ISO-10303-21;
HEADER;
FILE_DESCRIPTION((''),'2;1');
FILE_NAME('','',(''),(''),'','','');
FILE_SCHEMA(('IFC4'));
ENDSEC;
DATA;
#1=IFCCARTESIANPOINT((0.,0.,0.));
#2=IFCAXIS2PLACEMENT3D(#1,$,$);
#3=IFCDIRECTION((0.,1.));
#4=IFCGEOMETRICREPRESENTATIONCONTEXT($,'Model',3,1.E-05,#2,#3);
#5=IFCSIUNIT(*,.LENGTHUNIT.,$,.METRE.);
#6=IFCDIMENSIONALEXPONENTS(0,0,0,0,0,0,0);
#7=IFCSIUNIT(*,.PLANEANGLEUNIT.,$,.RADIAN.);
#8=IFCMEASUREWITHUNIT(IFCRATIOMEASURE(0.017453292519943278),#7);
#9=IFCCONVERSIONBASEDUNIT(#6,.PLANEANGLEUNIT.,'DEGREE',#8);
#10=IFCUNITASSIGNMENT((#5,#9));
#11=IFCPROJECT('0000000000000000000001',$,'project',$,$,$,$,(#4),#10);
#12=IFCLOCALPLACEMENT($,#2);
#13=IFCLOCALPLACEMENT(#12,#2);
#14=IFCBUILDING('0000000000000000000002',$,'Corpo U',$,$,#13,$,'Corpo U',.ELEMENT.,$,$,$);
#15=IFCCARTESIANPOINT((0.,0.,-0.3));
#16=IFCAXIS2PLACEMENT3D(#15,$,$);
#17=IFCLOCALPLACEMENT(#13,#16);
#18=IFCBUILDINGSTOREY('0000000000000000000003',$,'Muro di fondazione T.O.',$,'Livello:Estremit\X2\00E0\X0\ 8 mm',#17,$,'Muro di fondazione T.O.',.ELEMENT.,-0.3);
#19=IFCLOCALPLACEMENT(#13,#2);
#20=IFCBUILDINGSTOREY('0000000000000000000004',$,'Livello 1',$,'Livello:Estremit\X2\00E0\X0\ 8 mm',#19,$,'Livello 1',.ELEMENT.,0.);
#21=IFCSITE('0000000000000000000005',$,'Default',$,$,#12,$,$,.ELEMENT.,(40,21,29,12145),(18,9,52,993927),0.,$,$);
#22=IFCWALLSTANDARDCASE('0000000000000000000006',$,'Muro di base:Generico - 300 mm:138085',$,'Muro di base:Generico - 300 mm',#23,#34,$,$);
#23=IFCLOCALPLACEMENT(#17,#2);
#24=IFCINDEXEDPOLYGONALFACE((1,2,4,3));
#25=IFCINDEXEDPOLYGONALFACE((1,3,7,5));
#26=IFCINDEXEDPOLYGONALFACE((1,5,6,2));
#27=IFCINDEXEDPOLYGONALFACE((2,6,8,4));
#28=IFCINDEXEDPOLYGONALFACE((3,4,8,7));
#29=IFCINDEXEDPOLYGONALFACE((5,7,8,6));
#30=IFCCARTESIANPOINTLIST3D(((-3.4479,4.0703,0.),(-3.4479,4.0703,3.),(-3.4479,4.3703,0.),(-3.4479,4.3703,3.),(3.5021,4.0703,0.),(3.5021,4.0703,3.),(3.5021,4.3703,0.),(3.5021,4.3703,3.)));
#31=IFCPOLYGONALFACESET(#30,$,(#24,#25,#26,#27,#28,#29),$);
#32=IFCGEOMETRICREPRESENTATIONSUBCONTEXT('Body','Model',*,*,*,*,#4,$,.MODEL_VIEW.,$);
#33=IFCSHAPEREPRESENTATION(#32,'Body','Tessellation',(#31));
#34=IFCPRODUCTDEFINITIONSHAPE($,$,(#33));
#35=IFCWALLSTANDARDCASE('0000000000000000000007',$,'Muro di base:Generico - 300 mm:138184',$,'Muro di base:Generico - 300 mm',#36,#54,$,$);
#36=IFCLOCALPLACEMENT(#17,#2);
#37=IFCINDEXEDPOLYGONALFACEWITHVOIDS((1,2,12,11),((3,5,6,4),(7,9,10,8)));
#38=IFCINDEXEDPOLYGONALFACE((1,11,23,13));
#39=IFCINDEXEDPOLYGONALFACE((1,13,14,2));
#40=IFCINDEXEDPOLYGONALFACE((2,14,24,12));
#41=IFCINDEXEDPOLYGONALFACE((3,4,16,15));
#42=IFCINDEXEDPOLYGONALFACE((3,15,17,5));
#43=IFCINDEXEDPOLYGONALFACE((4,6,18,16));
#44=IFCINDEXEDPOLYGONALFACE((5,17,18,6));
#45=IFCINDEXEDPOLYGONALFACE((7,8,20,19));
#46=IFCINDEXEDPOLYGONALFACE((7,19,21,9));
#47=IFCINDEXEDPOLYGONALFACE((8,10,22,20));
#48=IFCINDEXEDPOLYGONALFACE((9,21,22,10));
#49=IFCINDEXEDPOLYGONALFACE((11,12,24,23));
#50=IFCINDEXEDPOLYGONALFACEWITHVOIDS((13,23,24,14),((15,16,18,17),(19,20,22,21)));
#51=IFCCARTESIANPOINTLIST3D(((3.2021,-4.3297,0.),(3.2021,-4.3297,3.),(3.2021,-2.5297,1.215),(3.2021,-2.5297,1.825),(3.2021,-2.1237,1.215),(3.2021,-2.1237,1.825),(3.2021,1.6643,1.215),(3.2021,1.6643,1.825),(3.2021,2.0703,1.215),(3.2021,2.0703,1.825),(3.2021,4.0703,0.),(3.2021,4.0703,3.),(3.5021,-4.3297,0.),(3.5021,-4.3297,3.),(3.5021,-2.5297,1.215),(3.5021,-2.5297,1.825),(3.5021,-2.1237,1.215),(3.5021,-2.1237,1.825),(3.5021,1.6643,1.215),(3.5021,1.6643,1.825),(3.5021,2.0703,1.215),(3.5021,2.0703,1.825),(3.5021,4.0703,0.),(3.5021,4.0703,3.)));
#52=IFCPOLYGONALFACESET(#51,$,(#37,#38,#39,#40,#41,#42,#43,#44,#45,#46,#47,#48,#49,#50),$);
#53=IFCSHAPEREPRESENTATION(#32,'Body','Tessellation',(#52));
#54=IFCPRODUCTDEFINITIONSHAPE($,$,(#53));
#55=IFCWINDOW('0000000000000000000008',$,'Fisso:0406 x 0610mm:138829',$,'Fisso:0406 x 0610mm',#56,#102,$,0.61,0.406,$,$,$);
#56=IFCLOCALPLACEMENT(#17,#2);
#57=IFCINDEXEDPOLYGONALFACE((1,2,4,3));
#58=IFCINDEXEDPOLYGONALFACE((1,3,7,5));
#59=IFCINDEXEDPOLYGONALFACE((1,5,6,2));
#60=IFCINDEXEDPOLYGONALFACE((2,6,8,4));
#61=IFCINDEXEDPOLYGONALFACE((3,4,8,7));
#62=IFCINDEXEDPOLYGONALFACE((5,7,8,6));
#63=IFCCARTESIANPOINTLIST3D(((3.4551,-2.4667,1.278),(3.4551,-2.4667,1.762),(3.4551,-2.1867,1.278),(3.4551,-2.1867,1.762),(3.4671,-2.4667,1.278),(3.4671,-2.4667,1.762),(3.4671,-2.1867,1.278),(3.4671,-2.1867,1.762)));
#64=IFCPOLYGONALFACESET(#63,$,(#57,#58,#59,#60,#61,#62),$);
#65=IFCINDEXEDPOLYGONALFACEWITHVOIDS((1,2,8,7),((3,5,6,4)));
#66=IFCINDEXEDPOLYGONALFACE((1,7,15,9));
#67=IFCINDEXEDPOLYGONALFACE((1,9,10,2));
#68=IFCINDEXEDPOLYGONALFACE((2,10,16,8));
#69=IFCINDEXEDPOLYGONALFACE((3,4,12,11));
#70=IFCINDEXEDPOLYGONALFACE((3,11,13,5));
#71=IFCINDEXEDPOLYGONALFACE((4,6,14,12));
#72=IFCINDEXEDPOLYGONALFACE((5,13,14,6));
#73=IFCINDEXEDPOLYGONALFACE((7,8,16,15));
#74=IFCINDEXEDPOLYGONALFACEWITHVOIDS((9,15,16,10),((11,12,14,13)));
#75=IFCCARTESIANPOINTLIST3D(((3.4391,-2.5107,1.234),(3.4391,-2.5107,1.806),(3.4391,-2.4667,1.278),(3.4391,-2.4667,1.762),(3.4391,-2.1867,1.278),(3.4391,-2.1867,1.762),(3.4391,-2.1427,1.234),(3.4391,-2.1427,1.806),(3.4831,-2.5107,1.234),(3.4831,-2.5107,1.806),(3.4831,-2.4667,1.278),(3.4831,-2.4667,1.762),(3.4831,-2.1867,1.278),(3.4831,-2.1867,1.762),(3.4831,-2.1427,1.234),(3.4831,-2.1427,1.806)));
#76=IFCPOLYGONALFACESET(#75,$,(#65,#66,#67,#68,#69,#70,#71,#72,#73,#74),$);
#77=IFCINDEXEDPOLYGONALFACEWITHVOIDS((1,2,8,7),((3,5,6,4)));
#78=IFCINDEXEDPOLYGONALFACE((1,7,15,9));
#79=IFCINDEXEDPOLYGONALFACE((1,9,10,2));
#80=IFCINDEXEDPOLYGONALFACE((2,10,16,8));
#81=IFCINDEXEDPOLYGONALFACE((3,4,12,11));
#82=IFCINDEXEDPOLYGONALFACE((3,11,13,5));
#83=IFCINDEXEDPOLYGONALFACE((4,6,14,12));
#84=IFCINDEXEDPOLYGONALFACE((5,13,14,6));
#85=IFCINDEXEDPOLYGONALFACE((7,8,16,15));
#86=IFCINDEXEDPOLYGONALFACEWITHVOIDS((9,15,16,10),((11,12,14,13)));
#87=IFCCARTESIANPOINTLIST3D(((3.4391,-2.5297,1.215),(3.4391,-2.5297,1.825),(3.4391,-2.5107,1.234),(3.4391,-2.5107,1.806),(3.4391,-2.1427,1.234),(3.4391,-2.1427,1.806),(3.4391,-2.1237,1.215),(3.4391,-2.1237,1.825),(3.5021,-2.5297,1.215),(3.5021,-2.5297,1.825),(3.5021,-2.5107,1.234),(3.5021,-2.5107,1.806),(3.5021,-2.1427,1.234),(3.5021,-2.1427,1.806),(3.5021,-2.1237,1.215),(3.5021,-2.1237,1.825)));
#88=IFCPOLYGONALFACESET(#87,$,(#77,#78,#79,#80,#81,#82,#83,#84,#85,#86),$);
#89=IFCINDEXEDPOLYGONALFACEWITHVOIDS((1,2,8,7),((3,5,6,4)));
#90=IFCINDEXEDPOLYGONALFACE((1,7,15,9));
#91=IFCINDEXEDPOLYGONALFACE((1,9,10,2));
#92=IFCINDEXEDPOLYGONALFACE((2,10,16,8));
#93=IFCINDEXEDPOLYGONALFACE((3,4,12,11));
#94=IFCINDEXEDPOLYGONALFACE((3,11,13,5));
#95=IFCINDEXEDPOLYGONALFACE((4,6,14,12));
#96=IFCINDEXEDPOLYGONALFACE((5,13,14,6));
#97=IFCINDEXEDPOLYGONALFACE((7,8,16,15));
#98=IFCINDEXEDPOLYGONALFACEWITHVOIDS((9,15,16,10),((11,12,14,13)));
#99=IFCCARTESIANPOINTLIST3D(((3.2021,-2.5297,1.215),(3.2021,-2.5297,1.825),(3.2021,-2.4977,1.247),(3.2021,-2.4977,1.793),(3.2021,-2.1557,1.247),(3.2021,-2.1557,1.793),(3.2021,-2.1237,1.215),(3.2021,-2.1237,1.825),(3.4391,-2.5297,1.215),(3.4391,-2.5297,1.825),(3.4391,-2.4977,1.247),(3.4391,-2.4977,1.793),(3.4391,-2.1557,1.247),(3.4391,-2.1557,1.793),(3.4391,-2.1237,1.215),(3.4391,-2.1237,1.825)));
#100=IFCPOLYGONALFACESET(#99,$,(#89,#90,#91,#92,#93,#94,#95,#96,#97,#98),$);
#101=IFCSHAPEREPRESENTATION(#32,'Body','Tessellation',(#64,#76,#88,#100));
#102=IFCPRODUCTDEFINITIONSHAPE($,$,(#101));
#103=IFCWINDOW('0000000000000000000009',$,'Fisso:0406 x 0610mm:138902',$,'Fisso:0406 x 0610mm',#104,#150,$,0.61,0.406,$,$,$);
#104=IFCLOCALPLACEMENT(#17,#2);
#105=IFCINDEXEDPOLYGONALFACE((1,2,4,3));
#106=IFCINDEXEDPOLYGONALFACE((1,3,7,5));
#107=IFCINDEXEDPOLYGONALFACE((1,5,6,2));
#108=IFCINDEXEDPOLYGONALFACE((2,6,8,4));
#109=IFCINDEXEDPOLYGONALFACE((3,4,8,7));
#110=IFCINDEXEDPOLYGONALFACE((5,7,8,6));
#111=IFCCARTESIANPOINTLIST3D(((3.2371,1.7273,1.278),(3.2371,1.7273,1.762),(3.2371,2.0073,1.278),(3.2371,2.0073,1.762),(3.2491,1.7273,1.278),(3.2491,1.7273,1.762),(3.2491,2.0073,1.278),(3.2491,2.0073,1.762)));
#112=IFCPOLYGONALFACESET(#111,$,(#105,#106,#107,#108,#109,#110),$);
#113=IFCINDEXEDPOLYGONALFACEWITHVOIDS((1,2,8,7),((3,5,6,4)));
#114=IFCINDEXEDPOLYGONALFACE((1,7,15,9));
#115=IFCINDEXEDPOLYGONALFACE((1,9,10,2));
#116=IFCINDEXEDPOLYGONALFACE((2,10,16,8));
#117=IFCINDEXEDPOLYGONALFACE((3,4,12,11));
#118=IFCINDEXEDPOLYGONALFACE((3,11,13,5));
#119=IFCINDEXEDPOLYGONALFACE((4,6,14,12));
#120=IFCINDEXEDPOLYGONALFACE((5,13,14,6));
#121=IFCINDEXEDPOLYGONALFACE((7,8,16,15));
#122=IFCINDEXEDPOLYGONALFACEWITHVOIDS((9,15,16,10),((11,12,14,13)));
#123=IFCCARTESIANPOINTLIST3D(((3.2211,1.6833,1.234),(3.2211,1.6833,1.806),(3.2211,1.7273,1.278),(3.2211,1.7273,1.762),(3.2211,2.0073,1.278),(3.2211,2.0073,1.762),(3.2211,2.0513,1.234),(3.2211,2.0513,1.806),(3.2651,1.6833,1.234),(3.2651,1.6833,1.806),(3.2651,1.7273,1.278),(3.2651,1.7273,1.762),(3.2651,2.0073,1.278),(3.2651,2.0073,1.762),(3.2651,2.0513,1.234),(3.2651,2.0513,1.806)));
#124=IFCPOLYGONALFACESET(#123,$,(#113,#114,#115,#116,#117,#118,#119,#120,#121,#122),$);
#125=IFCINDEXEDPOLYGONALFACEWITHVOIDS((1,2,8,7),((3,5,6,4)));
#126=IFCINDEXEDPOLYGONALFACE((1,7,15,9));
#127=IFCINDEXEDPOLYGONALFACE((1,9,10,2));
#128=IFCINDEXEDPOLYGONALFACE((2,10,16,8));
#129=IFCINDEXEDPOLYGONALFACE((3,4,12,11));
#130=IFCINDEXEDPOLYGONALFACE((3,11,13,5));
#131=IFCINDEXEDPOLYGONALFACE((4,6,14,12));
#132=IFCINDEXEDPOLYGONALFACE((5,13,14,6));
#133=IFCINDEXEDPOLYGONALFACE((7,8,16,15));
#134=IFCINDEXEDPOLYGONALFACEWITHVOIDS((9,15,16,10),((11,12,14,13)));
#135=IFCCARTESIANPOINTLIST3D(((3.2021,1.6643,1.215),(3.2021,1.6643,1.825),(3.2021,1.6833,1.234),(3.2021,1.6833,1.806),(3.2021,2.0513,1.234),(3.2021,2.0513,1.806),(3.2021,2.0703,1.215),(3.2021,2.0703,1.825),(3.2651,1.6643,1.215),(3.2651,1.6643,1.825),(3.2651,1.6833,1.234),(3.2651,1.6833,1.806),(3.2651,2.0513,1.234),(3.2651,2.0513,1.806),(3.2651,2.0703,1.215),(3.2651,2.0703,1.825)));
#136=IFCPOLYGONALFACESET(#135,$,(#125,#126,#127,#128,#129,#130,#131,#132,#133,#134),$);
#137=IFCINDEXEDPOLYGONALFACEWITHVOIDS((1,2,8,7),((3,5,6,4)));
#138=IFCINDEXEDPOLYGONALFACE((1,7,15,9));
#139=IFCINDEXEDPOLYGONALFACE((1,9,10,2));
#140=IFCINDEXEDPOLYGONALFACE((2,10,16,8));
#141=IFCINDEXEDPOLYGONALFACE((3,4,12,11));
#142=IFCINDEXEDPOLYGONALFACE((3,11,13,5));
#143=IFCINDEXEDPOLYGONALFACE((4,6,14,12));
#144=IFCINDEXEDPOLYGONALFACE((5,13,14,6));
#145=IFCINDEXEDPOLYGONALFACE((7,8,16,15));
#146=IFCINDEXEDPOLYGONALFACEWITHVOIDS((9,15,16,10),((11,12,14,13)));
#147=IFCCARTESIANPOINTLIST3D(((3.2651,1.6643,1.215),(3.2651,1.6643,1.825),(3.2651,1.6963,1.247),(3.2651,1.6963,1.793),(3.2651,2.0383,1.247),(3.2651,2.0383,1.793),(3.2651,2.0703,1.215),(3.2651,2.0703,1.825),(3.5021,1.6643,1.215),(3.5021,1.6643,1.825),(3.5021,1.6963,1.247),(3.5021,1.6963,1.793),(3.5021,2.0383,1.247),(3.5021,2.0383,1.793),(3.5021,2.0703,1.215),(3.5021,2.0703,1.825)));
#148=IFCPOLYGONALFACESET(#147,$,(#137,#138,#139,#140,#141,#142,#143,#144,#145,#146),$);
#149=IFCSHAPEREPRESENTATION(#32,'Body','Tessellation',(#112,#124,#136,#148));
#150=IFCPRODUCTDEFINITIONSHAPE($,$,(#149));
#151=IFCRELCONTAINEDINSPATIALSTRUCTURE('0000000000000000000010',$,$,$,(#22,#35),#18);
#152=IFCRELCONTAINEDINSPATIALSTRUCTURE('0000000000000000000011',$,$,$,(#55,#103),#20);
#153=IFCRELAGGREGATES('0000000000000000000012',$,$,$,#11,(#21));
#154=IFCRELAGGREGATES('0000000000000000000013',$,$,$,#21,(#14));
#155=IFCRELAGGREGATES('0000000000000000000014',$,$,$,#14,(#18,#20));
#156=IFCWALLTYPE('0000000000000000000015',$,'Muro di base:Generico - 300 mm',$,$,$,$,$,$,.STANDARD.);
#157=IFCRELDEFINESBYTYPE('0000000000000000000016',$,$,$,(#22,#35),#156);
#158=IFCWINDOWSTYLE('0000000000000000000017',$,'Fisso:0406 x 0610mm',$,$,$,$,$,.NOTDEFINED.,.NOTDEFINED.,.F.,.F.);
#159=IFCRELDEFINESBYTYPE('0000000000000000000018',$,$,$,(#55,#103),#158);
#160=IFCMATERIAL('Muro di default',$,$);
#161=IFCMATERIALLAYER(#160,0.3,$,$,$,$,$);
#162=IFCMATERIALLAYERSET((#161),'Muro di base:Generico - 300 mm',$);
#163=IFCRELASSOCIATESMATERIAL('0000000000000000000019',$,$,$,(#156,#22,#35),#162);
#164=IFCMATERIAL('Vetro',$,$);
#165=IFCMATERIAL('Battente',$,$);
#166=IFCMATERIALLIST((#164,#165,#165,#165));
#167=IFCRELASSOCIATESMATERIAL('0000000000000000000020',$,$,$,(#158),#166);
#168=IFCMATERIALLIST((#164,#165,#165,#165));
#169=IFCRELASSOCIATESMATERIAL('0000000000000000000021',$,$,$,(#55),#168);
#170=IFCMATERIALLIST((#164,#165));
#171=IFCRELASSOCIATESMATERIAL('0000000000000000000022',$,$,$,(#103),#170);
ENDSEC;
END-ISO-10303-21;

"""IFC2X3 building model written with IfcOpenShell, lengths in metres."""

from ifc_helpers import new_model, entity, si_unit, converted_unit, direction, frame, frame_2d, origin, place, context, subcontext, project, spatial, polyline, rectangle, outline, extrude, source, transform, mapped, material, material_list, layer, layer_set, layer_usage, type_object, type_shapes, element, fill, save


model = new_model("IFC2X3")

# Units and contexts
model_context = context("Model", 3, precision=1e-05, world=origin(), true_north=direction((0.0, 1.0)))
body_context = subcontext(model_context, "Body", "Model", "MODEL_VIEW")
ifc_project = project(units=[si_unit("LENGTHUNIT", "METRE"), converted_unit("PLANEANGLEUNIT", "DEGREE", entity("IfcRatioMeasure", 0.017453292519943278), si_unit("PLANEANGLEUNIT", "RADIAN"), dimensions=[0, 0, 0, 0, 0, 0, 0])], contexts=[model_context])

# Site, building, storey
site_placement = place(None, origin())
site = spatial("IfcSite", under=ifc_project, at=site_placement, Name="Default", CompositionType="ELEMENT", RefLatitude=(40, 21, 29, 12145), RefLongitude=(18, 9, 52, 993927), RefElevation=0.0)
building_placement = place(site_placement, origin())
building = spatial("IfcBuilding", under=site, at=building_placement, Name="Corpo U", LongName="Corpo U", CompositionType="ELEMENT")
storey_1_placement = place(building_placement, frame((0.0, 0.0, -0.3)))
storey_1 = spatial("IfcBuildingStorey", under=building, at=storey_1_placement, Name="Muro di fondazione T.O.", ObjectType="Livello:Estremità 8 mm", LongName="Muro di fondazione T.O.", CompositionType="ELEMENT", Elevation=-0.3)

# Wall
ifc_material_1 = material(Name="Muro di default")
ifc_layer = layer(ifc_material_1, 0.3)
ifc_layer_set = layer_set([ifc_layer], Name="Muro di base:Generico - 300 mm")
ifc_layer_usage_1 = layer_usage(ifc_layer_set, "AXIS2", "NEGATIVE", 0.15)
wall_type = type_object("IfcWallType", Name="Muro di base:Generico - 300 mm", PredefinedType="STANDARD", material=ifc_layer_set)
wall_1_placement = place(storey_1_placement, frame((-3.4479, 4.2203, 0.0)))
element("IfcWallStandardCase", 1, at=wall_1_placement, inside=storey_1, type_object=wall_type, material=ifc_layer_usage_1, Name="Muro di base:Generico - 300 mm:138085", ObjectType="Muro di base:Generico - 300 mm", context=body_context, shape_type="SweptSolid", body=[
    extrude(rectangle(XDim=6.95, YDim=0.3, at=frame_2d((3.475, 0.0), x_axis=(-1.0, 0.0))), origin(), (0.0, 0.0, 1.0), 3.0),
])

# Wall, openings
ifc_layer_usage_2 = layer_usage(ifc_layer_set, "AXIS2", "NEGATIVE", 0.15)
wall_2_placement = place(storey_1_placement, frame((3.3521, 4.0703, 0.0), z_axis=(0.0, 0.0, 1.0), x_axis=(0.0, -1.0, 0.0)))
wall_2 = element("IfcWallStandardCase", 2, at=wall_2_placement, inside=storey_1, type_object=wall_type, material=ifc_layer_usage_2, Name="Muro di base:Generico - 300 mm:138184", ObjectType="Muro di base:Generico - 300 mm", context=body_context, shape_type="SweptSolid", body=[
    extrude(rectangle(XDim=8.4, YDim=0.3, at=frame_2d((4.2, 0.0), x_axis=(-1.0, 0.0))), origin(), (0.0, 0.0, 1.0), 3.0),
])
opening_1_placement = place(wall_2_placement, frame((6.194, -0.15, 1.215)))
opening_1 = element("IfcOpeningElement", 3, at=opening_1_placement, cuts=wall_2, ObjectType="Opening", context=body_context, shape_type="SweptSolid", body=[
    extrude(rectangle(XDim=0.61, YDim=0.406, at=frame_2d((0.305, 0.203), x_axis=(1.0, 0.0))), frame((0.0, 0.0, 0.0), z_axis=(0.0, 1.0, 0.0), x_axis=(0.0, 0.0, 1.0)), (0.0, 0.0, 1.0), 0.3),
])
opening_2_placement = place(wall_2_placement, frame((2.406, 0.15, 1.215)))
opening_2 = element("IfcOpeningElement", 4, at=opening_2_placement, cuts=wall_2, ObjectType="Opening", context=body_context, shape_type="SweptSolid", body=[
    extrude(rectangle(XDim=0.61, YDim=0.406, at=frame_2d((0.305, 0.203), x_axis=(1.0, 0.0))), frame((0.0, 0.0, 0.0), z_axis=(0.0, -1.0, 0.0), x_axis=(0.0, 0.0, 1.0)), (0.0, 0.0, 1.0), 0.3),
])

# Shared definitions
storey_2_placement = place(building_placement, origin())
storey_2 = spatial("IfcBuildingStorey", under=building, at=storey_2_placement, Name="Livello 1", ObjectType="Livello:Estremità 8 mm", LongName="Livello 1", CompositionType="ELEMENT", Elevation=0.0)

# Windows
ifc_material_2 = material(Name="Vetro")
ifc_material_3 = material(Name="Battente")
ifc_material_list_1 = material_list([ifc_material_2, ifc_material_3, ifc_material_3, ifc_material_3])
ifc_material_list_2 = material_list([ifc_material_2, ifc_material_3, ifc_material_3, ifc_material_3])
window_style = type_object("IfcWindowStyle", Name="Fisso:0406 x 0610mm", ConstructionType="NOTDEFINED", OperationType="NOTDEFINED", ParameterTakesPrecedence=False, Sizeable=False, material=ifc_material_list_2)
shared_shape_1 = source(origin(), body_context, "Body", "SweptSolid", [
    extrude(rectangle(XDim=0.012, YDim=0.28, at=frame_2d((0.0, 0.0), x_axis=(1.0, 0.0))), frame((0.203, 0.259, 0.063), z_axis=(0.0, 0.0, 1.0), x_axis=(0.0, -1.0, 0.0)), (0.0, 0.0, 1.0), 0.484),
    extrude(outline(polyline([(-0.184, -0.286), (0.184, -0.286), (0.184, 0.286), (-0.184, 0.286), (-0.184, -0.286)]), holes=[polyline([(-0.14, -0.242), (-0.14, 0.242), (0.14, 0.242), (0.14, -0.242), (-0.14, -0.242)])]), frame((0.203, 0.237, 0.305), z_axis=(0.0, 1.0, 0.0), x_axis=(1.0, 0.0, 0.0)), (0.0, 0.0, 1.0), 0.044),
    extrude(outline(polyline([(-0.203, -0.305), (0.203, -0.305), (0.203, 0.305), (-0.203, 0.305), (-0.203, -0.305)]), holes=[polyline([(-0.184, -0.286), (-0.184, 0.286), (0.184, 0.286), (0.184, -0.286), (-0.184, -0.286)])]), frame((0.203, 0.237, 0.305), z_axis=(0.0, 1.0, 0.0), x_axis=(1.0, 0.0, 0.0)), (0.0, 0.0, 1.0), 0.063),
    extrude(outline(polyline([(-0.203, -0.305), (0.203, -0.305), (0.203, 0.305), (-0.203, 0.305), (-0.203, -0.305)]), holes=[polyline([(-0.171, -0.273), (-0.171, 0.273), (0.171, 0.273), (0.171, -0.273), (-0.171, -0.273)])]), frame((0.203, 0.0, 0.305), z_axis=(0.0, 1.0, 0.0), x_axis=(1.0, 0.0, 0.0)), (0.0, 0.0, 1.0), 0.237),
])
type_shapes(window_style, [shared_shape_1])
window_1_placement = place(opening_1_placement, origin())
window_1 = element("IfcWindow", 5, at=window_1_placement, inside=storey_2, type_object=window_style, material=ifc_material_list_1, Name="Fisso:0406 x 0610mm:138829", ObjectType="Fisso:0406 x 0610mm", OverallHeight=0.61, OverallWidth=0.406, context=body_context, shape_type="MappedRepresentation", body=[
    mapped(shared_shape_1, transform((0.0, 0.0, 0.0), scale=1.0)),
])
fill(opening_1, window_1)
ifc_material_list_3 = material_list([ifc_material_2, ifc_material_3])
window_2_placement = place(opening_2_placement, frame((0.0, 0.0, 0.0), z_axis=(0.0, 0.0, 1.0), x_axis=(-1.0, 0.0, 0.0)))
window_2 = element("IfcWindow", 6, at=window_2_placement, inside=storey_2, type_object=window_style, material=ifc_material_list_3, Name="Fisso:0406 x 0610mm:138902", ObjectType="Fisso:0406 x 0610mm", OverallHeight=0.61, OverallWidth=0.406, context=body_context, shape_type="MappedRepresentation", body=[
    mapped(shared_shape_1, transform((0.0, 0.0, 0.0), scale=1.0)),
])
fill(opening_2, window_2)

save(model, "model.ifc")
